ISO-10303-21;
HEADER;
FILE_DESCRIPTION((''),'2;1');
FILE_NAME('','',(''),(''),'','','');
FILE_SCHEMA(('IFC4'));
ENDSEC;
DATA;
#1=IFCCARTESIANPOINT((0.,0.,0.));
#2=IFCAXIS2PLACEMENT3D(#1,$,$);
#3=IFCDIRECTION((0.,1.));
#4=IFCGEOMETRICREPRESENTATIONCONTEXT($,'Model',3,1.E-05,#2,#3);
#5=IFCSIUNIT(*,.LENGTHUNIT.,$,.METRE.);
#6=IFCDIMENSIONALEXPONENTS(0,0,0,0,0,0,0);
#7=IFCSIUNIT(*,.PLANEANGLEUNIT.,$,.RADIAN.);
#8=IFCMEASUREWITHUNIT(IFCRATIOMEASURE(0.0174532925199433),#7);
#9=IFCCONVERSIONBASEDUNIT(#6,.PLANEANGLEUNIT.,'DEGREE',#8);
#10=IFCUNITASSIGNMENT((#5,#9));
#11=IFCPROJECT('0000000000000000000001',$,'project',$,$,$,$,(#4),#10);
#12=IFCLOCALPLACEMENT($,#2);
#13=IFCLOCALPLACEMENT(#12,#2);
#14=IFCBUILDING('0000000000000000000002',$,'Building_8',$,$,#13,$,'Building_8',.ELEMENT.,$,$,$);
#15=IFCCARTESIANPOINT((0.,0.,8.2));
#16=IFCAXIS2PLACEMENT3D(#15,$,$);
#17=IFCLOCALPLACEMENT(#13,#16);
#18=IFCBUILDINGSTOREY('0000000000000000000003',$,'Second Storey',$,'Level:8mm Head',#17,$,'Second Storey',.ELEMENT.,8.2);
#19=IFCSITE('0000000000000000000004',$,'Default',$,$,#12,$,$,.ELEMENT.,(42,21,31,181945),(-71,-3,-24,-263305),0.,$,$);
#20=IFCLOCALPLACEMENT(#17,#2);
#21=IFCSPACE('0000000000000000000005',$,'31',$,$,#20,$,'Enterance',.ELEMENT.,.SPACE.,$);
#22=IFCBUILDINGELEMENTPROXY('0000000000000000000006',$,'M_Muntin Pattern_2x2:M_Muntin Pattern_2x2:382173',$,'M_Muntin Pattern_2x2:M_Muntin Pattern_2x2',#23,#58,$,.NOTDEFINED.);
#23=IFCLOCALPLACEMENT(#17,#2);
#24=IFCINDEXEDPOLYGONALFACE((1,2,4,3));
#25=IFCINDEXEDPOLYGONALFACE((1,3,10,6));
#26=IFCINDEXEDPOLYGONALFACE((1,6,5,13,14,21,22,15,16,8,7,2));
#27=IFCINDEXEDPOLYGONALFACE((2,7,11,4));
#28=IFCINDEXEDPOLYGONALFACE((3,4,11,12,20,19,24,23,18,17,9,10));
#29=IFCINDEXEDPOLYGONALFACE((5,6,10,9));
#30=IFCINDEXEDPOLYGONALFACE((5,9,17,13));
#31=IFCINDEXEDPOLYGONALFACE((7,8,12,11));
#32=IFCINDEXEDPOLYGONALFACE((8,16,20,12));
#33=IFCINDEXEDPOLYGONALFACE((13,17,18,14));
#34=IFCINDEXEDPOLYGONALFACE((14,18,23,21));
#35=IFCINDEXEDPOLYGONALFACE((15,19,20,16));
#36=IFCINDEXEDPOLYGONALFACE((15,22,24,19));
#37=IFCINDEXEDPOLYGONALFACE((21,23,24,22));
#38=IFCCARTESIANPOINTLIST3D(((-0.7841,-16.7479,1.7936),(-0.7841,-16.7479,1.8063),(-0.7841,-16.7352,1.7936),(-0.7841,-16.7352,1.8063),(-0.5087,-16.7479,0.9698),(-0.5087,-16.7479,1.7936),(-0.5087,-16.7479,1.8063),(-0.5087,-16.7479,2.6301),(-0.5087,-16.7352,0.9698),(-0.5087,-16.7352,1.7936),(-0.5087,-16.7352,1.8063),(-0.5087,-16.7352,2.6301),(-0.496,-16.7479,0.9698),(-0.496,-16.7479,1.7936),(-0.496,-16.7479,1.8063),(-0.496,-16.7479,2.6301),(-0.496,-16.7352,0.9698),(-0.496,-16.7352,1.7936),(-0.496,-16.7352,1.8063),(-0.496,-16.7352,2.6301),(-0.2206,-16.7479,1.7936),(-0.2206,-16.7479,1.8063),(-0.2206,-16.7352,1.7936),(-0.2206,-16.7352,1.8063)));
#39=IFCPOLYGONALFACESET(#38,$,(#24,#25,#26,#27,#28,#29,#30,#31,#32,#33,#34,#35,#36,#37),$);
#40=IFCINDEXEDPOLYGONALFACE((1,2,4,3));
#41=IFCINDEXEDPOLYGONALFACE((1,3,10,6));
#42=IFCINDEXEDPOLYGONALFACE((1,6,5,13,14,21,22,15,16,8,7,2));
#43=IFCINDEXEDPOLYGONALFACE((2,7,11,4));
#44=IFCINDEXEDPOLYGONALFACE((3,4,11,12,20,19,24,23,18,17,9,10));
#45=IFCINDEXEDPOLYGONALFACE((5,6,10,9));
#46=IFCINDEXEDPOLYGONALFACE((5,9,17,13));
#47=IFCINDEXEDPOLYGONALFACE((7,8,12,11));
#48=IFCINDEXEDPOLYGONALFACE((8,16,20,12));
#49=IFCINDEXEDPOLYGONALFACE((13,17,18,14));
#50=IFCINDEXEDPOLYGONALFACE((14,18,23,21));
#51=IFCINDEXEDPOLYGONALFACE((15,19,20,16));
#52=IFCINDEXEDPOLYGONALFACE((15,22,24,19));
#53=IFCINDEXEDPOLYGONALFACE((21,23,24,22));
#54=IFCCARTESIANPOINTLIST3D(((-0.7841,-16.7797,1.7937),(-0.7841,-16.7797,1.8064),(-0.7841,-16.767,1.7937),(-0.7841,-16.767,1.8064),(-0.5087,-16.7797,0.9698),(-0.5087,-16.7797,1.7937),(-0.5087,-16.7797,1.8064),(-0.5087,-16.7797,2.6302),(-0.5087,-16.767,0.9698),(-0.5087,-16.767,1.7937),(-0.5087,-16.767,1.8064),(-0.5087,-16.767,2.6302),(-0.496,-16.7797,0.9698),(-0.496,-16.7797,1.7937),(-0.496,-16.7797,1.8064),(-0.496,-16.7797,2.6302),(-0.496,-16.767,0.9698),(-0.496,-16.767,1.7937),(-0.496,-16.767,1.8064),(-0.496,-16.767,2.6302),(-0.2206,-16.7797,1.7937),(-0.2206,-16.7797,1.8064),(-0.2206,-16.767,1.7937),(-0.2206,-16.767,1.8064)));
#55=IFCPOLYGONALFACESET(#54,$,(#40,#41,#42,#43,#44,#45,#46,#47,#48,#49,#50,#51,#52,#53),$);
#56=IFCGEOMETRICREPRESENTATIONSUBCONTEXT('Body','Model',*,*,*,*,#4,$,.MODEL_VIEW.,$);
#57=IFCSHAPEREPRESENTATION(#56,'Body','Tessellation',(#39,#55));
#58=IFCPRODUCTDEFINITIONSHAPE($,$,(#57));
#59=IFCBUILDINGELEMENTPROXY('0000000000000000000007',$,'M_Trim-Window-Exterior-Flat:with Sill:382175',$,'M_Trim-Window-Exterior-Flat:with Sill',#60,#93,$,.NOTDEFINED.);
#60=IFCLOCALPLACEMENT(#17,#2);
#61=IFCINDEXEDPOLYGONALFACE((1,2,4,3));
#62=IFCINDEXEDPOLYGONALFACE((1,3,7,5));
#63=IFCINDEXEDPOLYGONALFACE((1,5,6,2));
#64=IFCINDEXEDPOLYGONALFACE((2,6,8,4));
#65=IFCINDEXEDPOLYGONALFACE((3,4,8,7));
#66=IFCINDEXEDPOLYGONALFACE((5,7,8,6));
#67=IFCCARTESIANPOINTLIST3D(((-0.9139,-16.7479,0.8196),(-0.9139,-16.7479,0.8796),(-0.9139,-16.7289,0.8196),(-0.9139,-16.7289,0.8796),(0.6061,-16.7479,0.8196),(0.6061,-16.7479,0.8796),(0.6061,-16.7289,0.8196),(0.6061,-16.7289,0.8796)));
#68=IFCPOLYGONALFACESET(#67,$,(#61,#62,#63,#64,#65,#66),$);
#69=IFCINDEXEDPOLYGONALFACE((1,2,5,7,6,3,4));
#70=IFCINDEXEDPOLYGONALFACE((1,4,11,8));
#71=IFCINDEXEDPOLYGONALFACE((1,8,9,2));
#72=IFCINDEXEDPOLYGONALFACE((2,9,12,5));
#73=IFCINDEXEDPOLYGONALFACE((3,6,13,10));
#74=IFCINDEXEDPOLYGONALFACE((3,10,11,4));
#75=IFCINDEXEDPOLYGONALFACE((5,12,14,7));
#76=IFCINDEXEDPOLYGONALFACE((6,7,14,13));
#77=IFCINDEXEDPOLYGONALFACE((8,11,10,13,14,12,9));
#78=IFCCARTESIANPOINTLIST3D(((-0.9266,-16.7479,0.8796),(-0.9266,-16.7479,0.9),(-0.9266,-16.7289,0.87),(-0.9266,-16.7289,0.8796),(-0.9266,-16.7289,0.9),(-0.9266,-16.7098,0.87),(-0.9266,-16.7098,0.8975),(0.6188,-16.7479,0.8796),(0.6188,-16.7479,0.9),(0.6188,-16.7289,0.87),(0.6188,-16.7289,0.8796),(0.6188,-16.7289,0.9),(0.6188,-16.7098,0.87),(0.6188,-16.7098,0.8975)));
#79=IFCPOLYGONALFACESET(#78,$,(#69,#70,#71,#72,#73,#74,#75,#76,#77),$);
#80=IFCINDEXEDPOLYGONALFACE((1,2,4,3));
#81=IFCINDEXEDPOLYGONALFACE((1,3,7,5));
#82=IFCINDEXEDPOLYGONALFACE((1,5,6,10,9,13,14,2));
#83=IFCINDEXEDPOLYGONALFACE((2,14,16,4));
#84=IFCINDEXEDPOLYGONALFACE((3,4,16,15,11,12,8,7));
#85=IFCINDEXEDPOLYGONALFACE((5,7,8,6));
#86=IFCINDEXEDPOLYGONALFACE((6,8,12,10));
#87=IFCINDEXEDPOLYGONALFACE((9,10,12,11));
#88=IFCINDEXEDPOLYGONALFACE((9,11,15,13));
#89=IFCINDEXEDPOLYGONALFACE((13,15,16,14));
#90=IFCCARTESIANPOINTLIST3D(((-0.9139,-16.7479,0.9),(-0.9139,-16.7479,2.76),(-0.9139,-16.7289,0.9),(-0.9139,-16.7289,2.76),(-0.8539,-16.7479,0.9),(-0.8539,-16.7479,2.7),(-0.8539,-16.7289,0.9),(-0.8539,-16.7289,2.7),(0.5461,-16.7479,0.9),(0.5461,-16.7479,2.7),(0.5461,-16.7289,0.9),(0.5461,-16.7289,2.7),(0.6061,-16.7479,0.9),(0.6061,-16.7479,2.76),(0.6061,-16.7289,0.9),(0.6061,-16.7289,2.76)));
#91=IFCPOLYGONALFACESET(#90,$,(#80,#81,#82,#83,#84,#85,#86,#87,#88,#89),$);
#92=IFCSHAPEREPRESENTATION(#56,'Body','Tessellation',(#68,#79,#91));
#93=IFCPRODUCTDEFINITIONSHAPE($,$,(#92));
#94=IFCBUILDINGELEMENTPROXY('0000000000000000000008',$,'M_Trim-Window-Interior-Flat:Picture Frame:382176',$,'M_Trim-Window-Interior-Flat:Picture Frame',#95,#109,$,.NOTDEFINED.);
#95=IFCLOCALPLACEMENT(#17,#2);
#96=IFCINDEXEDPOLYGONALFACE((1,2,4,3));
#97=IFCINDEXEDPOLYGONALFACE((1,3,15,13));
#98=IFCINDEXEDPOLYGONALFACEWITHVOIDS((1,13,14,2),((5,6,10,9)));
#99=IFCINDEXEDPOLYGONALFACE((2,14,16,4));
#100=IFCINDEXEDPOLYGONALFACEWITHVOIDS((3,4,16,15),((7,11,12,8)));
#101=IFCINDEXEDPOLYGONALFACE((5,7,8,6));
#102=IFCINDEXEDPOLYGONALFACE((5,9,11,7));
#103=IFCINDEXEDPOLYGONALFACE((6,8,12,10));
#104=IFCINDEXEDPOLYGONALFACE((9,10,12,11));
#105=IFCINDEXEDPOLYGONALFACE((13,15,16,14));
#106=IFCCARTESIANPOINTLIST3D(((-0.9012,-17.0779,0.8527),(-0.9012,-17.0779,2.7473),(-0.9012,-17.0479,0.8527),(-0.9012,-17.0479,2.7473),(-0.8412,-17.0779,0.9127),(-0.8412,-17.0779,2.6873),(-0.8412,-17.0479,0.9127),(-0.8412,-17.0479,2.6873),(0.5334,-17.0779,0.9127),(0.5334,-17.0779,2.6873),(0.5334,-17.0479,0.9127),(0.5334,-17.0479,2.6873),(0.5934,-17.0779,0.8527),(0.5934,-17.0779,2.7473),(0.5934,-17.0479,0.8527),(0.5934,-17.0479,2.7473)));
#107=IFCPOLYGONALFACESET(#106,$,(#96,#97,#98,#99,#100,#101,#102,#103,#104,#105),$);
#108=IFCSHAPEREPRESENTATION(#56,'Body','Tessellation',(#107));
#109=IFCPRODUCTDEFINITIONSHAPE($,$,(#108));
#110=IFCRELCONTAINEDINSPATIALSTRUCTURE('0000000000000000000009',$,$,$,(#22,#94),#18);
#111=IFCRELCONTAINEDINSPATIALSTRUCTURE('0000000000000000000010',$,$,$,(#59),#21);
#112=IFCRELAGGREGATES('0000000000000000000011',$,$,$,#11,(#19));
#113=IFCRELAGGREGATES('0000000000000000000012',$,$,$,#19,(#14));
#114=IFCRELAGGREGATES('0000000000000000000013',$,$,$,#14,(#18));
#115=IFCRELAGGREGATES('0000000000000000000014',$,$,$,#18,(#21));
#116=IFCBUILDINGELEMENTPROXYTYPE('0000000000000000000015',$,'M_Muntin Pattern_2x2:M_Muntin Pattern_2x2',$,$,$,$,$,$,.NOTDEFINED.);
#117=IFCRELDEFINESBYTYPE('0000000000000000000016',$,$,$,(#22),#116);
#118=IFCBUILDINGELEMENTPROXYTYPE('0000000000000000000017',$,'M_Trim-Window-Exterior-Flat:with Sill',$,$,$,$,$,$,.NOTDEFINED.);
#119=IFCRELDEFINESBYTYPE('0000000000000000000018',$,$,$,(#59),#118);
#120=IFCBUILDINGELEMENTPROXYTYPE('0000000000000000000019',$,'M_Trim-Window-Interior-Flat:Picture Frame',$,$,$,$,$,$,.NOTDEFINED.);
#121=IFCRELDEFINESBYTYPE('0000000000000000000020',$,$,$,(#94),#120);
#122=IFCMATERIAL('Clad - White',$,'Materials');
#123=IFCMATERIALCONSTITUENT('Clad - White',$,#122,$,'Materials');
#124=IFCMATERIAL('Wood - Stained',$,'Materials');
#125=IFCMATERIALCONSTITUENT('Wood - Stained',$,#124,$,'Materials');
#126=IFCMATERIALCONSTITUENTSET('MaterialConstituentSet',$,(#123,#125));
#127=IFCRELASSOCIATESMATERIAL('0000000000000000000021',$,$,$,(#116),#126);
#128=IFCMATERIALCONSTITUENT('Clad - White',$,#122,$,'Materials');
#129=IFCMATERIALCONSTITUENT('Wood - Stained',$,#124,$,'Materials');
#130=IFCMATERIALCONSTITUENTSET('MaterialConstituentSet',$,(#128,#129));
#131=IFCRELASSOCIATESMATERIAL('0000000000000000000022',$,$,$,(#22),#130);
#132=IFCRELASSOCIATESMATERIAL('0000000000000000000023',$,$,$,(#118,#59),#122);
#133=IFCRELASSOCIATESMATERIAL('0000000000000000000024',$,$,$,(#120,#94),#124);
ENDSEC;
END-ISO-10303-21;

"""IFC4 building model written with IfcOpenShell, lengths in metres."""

from ifc_helpers import new_model, entity, si_unit, converted_unit, direction, frame, origin, place, context, subcontext, project, spatial, indexed_curve, outline, extrude, source, transform, mapped, material, constituent, constituent_set, type_object, type_shapes, element, save


model = new_model("IFC4")

# Units and contexts
model_context = context("Model", 3, precision=1e-05, world=origin(), true_north=direction((0.0, 1.0)))
body_context = subcontext(model_context, "Body", "Model", "MODEL_VIEW")
ifc_project = project(units=[si_unit("LENGTHUNIT", "METRE"), converted_unit("PLANEANGLEUNIT", "DEGREE", entity("IfcRatioMeasure", 0.0174532925199433), si_unit("PLANEANGLEUNIT", "RADIAN"), dimensions=[0, 0, 0, 0, 0, 0, 0])], contexts=[model_context])

# Site, building, storey
site_placement = place(None, origin())
site = spatial("IfcSite", under=ifc_project, at=site_placement, Name="Default", CompositionType="ELEMENT", RefLatitude=(42, 21, 31, 181945), RefLongitude=(-71, -3, -24, -263305), RefElevation=0.0)
building_placement = place(site_placement, origin())
building = spatial("IfcBuilding", under=site, at=building_placement, Name="Building_8", LongName="Building_8", CompositionType="ELEMENT")
storey_placement = place(building_placement, frame((0.0, 0.0, 8.2)))
storey = spatial("IfcBuildingStorey", under=building, at=storey_placement, Name="Second Storey", ObjectType="Level:8mm Head", LongName="Second Storey", CompositionType="ELEMENT", Elevation=8.2)

# Shared definitions
ifc_material_1 = material(Name="Clad - White", Category="Materials")
ifc_material_2 = material(Name="Wood - Stained", Category="Materials")

# Shared definitions
space_1_placement = place(storey_placement, origin())
space_1 = spatial("IfcSpace", under=storey, at=space_1_placement, Name="31", LongName="Enterance", CompositionType="ELEMENT", PredefinedType="SPACE")

# Building element proxies
ifc_constituent_1 = constituent(ifc_material_1, Name="Clad - White", Category="Materials")
ifc_constituent_2 = constituent(ifc_material_2, Name="Wood - Stained", Category="Materials")
ifc_constituent_set_1 = constituent_set(constituents=[ifc_constituent_1, ifc_constituent_2], Name="MaterialConstituentSet")
ifc_constituent_3 = constituent(ifc_material_1, Name="Clad - White", Category="Materials")
ifc_constituent_4 = constituent(ifc_material_2, Name="Wood - Stained", Category="Materials")
ifc_constituent_set_2 = constituent_set(constituents=[ifc_constituent_3, ifc_constituent_4], Name="MaterialConstituentSet")
building_element_proxy_type_1 = type_object("IfcBuildingElementProxyType", Name="M_Muntin Pattern_2x2:M_Muntin Pattern_2x2", PredefinedType="NOTDEFINED", material=ifc_constituent_set_2)
shared_shape_1 = source(origin(), body_context, "Body", "SweptSolid", [
    extrude(outline(indexed_curve([(0.0064, -0.0064), (0.8301, -0.0064), (0.8301, 0.0063), (0.0064, 0.0063), (0.0064, 0.2817), (-0.0063, 0.2817), (-0.0063, 0.0063), (-0.8302, 0.0063), (-0.8302, -0.0064), (-0.0063, -0.0064), (-0.0063, -0.2817), (0.0064, -0.2817), (0.0064, -0.0064)], self_intersect=False)), frame((0.0, 0.0095, 0.8301), z_axis=(0.0, 1.0, 0.0), x_axis=(0.0, 0.0, 1.0)), (0.0, 0.0, 1.0), 0.0127),
    extrude(outline(indexed_curve([(0.0064, -0.0064), (0.8302, -0.0064), (0.8302, 0.0063), (0.0064, 0.0063), (0.0064, 0.2817), (-0.0063, 0.2817), (-0.0063, 0.0063), (-0.8302, 0.0063), (-0.8302, -0.0064), (-0.0063, -0.0064), (-0.0063, -0.2817), (0.0064, -0.2817), (0.0064, -0.0064)], self_intersect=False)), frame((0.0, -0.0222, 0.8302), z_axis=(0.0, 1.0, 0.0), x_axis=(0.0, 0.0, 1.0)), (0.0, 0.0, 1.0), 0.0127),
])
type_shapes(building_element_proxy_type_1, [shared_shape_1])
proxy_1_placement = place(storey_placement, frame((-0.5023, -16.7575, 0.9698)))
element("IfcBuildingElementProxy", 1, at=proxy_1_placement, inside=storey, type_object=building_element_proxy_type_1, material=ifc_constituent_set_1, Name="M_Muntin Pattern_2x2:M_Muntin Pattern_2x2:382173", ObjectType="M_Muntin Pattern_2x2:M_Muntin Pattern_2x2", PredefinedType="NOTDEFINED", context=body_context, shape_type="MappedRepresentation", body=[
    mapped(shared_shape_1, transform((0.0, 0.0, 0.0), scale=1.0)),
])
building_element_proxy_type_2 = type_object("IfcBuildingElementProxyType", Name="M_Trim-Window-Exterior-Flat:with Sill", PredefinedType="NOTDEFINED", material=ifc_material_1)
shared_shape_2 = source(origin(), body_context, "Body", "SweptSolid", [
    extrude(outline(indexed_curve([(-0.76, -0.03), (0.76, -0.03), (0.76, 0.03), (-0.76, 0.03), (-0.76, -0.03)], self_intersect=False)), frame((0.0, -1.8504, 0.0), z_axis=(0.0, 0.0, 1.0), x_axis=(-1.0, 0.0, 0.0)), (0.0, 0.0, 1.0), 0.0191),
    extrude(outline(indexed_curve([(-0.019, -0.0152), (0.0, -0.0152), (0.0, -0.0057), (0.019, -0.0057), (0.019, 0.0148), (0.0, 0.0148), (-0.019, 0.0123), (-0.019, -0.0152)], self_intersect=False)), frame((-0.7727, -1.8148, 0.019), z_axis=(1.0, 0.0, 0.0), x_axis=(0.0, 0.0, -1.0)), (0.0, 0.0, 1.0), 1.5454),
    extrude(outline(indexed_curve([(-0.945, -0.76), (0.915, -0.76), (0.915, -0.7), (-0.885, -0.7), (-0.885, 0.7), (0.915, 0.7), (0.915, 0.76), (-0.945, 0.76), (-0.945, -0.76)], self_intersect=False)), frame((0.0, -0.885, 0.0), z_axis=(0.0, 0.0, 1.0), x_axis=(0.0, -1.0, 0.0)), (0.0, 0.0, 1.0), 0.0191),
])
type_shapes(building_element_proxy_type_2, [shared_shape_2])
proxy_2_placement = place(space_1_placement, frame((-0.1539, -16.7479, 2.7), z_axis=(0.0, 1.0, 0.0), x_axis=(-1.0, 0.0, 0.0)))
element("IfcBuildingElementProxy", 2, at=proxy_2_placement, inside=space_1, type_object=building_element_proxy_type_2, material=ifc_material_1, Name="M_Trim-Window-Exterior-Flat:with Sill:382175", ObjectType="M_Trim-Window-Exterior-Flat:with Sill", PredefinedType="NOTDEFINED", context=body_context, shape_type="MappedRepresentation", body=[
    mapped(shared_shape_2, transform((0.0, 0.0, 0.0), scale=1.0)),
])
building_element_proxy_type_3 = type_object("IfcBuildingElementProxyType", Name="M_Trim-Window-Interior-Flat:Picture Frame", PredefinedType="NOTDEFINED", material=ifc_material_2)
shared_shape_3 = source(origin(), body_context, "Body", "SweptSolid", [
    extrude(outline(indexed_curve([(-0.7473, -0.9473), (0.7473, -0.9473), (0.7473, 0.9473), (-0.7473, 0.9473), (-0.7473, -0.9473)], self_intersect=False), holes=[indexed_curve([(-0.6873, -0.8873), (-0.6873, 0.8873), (0.6873, 0.8873), (0.6873, -0.8873), (-0.6873, -0.8873)], self_intersect=False)]), frame((0.0, -0.9, 0.0), z_axis=(0.0, 0.0, 1.0), x_axis=(-1.0, 0.0, 0.0)), (0.0, 0.0, 1.0), 0.03),
])
type_shapes(building_element_proxy_type_3, [shared_shape_3])
proxy_3_placement = place(storey_placement, frame((-0.1539, -17.0479, 2.7), z_axis=(0.0, -1.0, 0.0), x_axis=(1.0, 0.0, 0.0)))
element("IfcBuildingElementProxy", 3, at=proxy_3_placement, inside=storey, type_object=building_element_proxy_type_3, material=ifc_material_2, Name="M_Trim-Window-Interior-Flat:Picture Frame:382176", ObjectType="M_Trim-Window-Interior-Flat:Picture Frame", PredefinedType="NOTDEFINED", context=body_context, shape_type="MappedRepresentation", body=[
    mapped(shared_shape_3, transform((0.0, 0.0, 0.0), scale=1.0)),
])

save(model, "model.ifc")
